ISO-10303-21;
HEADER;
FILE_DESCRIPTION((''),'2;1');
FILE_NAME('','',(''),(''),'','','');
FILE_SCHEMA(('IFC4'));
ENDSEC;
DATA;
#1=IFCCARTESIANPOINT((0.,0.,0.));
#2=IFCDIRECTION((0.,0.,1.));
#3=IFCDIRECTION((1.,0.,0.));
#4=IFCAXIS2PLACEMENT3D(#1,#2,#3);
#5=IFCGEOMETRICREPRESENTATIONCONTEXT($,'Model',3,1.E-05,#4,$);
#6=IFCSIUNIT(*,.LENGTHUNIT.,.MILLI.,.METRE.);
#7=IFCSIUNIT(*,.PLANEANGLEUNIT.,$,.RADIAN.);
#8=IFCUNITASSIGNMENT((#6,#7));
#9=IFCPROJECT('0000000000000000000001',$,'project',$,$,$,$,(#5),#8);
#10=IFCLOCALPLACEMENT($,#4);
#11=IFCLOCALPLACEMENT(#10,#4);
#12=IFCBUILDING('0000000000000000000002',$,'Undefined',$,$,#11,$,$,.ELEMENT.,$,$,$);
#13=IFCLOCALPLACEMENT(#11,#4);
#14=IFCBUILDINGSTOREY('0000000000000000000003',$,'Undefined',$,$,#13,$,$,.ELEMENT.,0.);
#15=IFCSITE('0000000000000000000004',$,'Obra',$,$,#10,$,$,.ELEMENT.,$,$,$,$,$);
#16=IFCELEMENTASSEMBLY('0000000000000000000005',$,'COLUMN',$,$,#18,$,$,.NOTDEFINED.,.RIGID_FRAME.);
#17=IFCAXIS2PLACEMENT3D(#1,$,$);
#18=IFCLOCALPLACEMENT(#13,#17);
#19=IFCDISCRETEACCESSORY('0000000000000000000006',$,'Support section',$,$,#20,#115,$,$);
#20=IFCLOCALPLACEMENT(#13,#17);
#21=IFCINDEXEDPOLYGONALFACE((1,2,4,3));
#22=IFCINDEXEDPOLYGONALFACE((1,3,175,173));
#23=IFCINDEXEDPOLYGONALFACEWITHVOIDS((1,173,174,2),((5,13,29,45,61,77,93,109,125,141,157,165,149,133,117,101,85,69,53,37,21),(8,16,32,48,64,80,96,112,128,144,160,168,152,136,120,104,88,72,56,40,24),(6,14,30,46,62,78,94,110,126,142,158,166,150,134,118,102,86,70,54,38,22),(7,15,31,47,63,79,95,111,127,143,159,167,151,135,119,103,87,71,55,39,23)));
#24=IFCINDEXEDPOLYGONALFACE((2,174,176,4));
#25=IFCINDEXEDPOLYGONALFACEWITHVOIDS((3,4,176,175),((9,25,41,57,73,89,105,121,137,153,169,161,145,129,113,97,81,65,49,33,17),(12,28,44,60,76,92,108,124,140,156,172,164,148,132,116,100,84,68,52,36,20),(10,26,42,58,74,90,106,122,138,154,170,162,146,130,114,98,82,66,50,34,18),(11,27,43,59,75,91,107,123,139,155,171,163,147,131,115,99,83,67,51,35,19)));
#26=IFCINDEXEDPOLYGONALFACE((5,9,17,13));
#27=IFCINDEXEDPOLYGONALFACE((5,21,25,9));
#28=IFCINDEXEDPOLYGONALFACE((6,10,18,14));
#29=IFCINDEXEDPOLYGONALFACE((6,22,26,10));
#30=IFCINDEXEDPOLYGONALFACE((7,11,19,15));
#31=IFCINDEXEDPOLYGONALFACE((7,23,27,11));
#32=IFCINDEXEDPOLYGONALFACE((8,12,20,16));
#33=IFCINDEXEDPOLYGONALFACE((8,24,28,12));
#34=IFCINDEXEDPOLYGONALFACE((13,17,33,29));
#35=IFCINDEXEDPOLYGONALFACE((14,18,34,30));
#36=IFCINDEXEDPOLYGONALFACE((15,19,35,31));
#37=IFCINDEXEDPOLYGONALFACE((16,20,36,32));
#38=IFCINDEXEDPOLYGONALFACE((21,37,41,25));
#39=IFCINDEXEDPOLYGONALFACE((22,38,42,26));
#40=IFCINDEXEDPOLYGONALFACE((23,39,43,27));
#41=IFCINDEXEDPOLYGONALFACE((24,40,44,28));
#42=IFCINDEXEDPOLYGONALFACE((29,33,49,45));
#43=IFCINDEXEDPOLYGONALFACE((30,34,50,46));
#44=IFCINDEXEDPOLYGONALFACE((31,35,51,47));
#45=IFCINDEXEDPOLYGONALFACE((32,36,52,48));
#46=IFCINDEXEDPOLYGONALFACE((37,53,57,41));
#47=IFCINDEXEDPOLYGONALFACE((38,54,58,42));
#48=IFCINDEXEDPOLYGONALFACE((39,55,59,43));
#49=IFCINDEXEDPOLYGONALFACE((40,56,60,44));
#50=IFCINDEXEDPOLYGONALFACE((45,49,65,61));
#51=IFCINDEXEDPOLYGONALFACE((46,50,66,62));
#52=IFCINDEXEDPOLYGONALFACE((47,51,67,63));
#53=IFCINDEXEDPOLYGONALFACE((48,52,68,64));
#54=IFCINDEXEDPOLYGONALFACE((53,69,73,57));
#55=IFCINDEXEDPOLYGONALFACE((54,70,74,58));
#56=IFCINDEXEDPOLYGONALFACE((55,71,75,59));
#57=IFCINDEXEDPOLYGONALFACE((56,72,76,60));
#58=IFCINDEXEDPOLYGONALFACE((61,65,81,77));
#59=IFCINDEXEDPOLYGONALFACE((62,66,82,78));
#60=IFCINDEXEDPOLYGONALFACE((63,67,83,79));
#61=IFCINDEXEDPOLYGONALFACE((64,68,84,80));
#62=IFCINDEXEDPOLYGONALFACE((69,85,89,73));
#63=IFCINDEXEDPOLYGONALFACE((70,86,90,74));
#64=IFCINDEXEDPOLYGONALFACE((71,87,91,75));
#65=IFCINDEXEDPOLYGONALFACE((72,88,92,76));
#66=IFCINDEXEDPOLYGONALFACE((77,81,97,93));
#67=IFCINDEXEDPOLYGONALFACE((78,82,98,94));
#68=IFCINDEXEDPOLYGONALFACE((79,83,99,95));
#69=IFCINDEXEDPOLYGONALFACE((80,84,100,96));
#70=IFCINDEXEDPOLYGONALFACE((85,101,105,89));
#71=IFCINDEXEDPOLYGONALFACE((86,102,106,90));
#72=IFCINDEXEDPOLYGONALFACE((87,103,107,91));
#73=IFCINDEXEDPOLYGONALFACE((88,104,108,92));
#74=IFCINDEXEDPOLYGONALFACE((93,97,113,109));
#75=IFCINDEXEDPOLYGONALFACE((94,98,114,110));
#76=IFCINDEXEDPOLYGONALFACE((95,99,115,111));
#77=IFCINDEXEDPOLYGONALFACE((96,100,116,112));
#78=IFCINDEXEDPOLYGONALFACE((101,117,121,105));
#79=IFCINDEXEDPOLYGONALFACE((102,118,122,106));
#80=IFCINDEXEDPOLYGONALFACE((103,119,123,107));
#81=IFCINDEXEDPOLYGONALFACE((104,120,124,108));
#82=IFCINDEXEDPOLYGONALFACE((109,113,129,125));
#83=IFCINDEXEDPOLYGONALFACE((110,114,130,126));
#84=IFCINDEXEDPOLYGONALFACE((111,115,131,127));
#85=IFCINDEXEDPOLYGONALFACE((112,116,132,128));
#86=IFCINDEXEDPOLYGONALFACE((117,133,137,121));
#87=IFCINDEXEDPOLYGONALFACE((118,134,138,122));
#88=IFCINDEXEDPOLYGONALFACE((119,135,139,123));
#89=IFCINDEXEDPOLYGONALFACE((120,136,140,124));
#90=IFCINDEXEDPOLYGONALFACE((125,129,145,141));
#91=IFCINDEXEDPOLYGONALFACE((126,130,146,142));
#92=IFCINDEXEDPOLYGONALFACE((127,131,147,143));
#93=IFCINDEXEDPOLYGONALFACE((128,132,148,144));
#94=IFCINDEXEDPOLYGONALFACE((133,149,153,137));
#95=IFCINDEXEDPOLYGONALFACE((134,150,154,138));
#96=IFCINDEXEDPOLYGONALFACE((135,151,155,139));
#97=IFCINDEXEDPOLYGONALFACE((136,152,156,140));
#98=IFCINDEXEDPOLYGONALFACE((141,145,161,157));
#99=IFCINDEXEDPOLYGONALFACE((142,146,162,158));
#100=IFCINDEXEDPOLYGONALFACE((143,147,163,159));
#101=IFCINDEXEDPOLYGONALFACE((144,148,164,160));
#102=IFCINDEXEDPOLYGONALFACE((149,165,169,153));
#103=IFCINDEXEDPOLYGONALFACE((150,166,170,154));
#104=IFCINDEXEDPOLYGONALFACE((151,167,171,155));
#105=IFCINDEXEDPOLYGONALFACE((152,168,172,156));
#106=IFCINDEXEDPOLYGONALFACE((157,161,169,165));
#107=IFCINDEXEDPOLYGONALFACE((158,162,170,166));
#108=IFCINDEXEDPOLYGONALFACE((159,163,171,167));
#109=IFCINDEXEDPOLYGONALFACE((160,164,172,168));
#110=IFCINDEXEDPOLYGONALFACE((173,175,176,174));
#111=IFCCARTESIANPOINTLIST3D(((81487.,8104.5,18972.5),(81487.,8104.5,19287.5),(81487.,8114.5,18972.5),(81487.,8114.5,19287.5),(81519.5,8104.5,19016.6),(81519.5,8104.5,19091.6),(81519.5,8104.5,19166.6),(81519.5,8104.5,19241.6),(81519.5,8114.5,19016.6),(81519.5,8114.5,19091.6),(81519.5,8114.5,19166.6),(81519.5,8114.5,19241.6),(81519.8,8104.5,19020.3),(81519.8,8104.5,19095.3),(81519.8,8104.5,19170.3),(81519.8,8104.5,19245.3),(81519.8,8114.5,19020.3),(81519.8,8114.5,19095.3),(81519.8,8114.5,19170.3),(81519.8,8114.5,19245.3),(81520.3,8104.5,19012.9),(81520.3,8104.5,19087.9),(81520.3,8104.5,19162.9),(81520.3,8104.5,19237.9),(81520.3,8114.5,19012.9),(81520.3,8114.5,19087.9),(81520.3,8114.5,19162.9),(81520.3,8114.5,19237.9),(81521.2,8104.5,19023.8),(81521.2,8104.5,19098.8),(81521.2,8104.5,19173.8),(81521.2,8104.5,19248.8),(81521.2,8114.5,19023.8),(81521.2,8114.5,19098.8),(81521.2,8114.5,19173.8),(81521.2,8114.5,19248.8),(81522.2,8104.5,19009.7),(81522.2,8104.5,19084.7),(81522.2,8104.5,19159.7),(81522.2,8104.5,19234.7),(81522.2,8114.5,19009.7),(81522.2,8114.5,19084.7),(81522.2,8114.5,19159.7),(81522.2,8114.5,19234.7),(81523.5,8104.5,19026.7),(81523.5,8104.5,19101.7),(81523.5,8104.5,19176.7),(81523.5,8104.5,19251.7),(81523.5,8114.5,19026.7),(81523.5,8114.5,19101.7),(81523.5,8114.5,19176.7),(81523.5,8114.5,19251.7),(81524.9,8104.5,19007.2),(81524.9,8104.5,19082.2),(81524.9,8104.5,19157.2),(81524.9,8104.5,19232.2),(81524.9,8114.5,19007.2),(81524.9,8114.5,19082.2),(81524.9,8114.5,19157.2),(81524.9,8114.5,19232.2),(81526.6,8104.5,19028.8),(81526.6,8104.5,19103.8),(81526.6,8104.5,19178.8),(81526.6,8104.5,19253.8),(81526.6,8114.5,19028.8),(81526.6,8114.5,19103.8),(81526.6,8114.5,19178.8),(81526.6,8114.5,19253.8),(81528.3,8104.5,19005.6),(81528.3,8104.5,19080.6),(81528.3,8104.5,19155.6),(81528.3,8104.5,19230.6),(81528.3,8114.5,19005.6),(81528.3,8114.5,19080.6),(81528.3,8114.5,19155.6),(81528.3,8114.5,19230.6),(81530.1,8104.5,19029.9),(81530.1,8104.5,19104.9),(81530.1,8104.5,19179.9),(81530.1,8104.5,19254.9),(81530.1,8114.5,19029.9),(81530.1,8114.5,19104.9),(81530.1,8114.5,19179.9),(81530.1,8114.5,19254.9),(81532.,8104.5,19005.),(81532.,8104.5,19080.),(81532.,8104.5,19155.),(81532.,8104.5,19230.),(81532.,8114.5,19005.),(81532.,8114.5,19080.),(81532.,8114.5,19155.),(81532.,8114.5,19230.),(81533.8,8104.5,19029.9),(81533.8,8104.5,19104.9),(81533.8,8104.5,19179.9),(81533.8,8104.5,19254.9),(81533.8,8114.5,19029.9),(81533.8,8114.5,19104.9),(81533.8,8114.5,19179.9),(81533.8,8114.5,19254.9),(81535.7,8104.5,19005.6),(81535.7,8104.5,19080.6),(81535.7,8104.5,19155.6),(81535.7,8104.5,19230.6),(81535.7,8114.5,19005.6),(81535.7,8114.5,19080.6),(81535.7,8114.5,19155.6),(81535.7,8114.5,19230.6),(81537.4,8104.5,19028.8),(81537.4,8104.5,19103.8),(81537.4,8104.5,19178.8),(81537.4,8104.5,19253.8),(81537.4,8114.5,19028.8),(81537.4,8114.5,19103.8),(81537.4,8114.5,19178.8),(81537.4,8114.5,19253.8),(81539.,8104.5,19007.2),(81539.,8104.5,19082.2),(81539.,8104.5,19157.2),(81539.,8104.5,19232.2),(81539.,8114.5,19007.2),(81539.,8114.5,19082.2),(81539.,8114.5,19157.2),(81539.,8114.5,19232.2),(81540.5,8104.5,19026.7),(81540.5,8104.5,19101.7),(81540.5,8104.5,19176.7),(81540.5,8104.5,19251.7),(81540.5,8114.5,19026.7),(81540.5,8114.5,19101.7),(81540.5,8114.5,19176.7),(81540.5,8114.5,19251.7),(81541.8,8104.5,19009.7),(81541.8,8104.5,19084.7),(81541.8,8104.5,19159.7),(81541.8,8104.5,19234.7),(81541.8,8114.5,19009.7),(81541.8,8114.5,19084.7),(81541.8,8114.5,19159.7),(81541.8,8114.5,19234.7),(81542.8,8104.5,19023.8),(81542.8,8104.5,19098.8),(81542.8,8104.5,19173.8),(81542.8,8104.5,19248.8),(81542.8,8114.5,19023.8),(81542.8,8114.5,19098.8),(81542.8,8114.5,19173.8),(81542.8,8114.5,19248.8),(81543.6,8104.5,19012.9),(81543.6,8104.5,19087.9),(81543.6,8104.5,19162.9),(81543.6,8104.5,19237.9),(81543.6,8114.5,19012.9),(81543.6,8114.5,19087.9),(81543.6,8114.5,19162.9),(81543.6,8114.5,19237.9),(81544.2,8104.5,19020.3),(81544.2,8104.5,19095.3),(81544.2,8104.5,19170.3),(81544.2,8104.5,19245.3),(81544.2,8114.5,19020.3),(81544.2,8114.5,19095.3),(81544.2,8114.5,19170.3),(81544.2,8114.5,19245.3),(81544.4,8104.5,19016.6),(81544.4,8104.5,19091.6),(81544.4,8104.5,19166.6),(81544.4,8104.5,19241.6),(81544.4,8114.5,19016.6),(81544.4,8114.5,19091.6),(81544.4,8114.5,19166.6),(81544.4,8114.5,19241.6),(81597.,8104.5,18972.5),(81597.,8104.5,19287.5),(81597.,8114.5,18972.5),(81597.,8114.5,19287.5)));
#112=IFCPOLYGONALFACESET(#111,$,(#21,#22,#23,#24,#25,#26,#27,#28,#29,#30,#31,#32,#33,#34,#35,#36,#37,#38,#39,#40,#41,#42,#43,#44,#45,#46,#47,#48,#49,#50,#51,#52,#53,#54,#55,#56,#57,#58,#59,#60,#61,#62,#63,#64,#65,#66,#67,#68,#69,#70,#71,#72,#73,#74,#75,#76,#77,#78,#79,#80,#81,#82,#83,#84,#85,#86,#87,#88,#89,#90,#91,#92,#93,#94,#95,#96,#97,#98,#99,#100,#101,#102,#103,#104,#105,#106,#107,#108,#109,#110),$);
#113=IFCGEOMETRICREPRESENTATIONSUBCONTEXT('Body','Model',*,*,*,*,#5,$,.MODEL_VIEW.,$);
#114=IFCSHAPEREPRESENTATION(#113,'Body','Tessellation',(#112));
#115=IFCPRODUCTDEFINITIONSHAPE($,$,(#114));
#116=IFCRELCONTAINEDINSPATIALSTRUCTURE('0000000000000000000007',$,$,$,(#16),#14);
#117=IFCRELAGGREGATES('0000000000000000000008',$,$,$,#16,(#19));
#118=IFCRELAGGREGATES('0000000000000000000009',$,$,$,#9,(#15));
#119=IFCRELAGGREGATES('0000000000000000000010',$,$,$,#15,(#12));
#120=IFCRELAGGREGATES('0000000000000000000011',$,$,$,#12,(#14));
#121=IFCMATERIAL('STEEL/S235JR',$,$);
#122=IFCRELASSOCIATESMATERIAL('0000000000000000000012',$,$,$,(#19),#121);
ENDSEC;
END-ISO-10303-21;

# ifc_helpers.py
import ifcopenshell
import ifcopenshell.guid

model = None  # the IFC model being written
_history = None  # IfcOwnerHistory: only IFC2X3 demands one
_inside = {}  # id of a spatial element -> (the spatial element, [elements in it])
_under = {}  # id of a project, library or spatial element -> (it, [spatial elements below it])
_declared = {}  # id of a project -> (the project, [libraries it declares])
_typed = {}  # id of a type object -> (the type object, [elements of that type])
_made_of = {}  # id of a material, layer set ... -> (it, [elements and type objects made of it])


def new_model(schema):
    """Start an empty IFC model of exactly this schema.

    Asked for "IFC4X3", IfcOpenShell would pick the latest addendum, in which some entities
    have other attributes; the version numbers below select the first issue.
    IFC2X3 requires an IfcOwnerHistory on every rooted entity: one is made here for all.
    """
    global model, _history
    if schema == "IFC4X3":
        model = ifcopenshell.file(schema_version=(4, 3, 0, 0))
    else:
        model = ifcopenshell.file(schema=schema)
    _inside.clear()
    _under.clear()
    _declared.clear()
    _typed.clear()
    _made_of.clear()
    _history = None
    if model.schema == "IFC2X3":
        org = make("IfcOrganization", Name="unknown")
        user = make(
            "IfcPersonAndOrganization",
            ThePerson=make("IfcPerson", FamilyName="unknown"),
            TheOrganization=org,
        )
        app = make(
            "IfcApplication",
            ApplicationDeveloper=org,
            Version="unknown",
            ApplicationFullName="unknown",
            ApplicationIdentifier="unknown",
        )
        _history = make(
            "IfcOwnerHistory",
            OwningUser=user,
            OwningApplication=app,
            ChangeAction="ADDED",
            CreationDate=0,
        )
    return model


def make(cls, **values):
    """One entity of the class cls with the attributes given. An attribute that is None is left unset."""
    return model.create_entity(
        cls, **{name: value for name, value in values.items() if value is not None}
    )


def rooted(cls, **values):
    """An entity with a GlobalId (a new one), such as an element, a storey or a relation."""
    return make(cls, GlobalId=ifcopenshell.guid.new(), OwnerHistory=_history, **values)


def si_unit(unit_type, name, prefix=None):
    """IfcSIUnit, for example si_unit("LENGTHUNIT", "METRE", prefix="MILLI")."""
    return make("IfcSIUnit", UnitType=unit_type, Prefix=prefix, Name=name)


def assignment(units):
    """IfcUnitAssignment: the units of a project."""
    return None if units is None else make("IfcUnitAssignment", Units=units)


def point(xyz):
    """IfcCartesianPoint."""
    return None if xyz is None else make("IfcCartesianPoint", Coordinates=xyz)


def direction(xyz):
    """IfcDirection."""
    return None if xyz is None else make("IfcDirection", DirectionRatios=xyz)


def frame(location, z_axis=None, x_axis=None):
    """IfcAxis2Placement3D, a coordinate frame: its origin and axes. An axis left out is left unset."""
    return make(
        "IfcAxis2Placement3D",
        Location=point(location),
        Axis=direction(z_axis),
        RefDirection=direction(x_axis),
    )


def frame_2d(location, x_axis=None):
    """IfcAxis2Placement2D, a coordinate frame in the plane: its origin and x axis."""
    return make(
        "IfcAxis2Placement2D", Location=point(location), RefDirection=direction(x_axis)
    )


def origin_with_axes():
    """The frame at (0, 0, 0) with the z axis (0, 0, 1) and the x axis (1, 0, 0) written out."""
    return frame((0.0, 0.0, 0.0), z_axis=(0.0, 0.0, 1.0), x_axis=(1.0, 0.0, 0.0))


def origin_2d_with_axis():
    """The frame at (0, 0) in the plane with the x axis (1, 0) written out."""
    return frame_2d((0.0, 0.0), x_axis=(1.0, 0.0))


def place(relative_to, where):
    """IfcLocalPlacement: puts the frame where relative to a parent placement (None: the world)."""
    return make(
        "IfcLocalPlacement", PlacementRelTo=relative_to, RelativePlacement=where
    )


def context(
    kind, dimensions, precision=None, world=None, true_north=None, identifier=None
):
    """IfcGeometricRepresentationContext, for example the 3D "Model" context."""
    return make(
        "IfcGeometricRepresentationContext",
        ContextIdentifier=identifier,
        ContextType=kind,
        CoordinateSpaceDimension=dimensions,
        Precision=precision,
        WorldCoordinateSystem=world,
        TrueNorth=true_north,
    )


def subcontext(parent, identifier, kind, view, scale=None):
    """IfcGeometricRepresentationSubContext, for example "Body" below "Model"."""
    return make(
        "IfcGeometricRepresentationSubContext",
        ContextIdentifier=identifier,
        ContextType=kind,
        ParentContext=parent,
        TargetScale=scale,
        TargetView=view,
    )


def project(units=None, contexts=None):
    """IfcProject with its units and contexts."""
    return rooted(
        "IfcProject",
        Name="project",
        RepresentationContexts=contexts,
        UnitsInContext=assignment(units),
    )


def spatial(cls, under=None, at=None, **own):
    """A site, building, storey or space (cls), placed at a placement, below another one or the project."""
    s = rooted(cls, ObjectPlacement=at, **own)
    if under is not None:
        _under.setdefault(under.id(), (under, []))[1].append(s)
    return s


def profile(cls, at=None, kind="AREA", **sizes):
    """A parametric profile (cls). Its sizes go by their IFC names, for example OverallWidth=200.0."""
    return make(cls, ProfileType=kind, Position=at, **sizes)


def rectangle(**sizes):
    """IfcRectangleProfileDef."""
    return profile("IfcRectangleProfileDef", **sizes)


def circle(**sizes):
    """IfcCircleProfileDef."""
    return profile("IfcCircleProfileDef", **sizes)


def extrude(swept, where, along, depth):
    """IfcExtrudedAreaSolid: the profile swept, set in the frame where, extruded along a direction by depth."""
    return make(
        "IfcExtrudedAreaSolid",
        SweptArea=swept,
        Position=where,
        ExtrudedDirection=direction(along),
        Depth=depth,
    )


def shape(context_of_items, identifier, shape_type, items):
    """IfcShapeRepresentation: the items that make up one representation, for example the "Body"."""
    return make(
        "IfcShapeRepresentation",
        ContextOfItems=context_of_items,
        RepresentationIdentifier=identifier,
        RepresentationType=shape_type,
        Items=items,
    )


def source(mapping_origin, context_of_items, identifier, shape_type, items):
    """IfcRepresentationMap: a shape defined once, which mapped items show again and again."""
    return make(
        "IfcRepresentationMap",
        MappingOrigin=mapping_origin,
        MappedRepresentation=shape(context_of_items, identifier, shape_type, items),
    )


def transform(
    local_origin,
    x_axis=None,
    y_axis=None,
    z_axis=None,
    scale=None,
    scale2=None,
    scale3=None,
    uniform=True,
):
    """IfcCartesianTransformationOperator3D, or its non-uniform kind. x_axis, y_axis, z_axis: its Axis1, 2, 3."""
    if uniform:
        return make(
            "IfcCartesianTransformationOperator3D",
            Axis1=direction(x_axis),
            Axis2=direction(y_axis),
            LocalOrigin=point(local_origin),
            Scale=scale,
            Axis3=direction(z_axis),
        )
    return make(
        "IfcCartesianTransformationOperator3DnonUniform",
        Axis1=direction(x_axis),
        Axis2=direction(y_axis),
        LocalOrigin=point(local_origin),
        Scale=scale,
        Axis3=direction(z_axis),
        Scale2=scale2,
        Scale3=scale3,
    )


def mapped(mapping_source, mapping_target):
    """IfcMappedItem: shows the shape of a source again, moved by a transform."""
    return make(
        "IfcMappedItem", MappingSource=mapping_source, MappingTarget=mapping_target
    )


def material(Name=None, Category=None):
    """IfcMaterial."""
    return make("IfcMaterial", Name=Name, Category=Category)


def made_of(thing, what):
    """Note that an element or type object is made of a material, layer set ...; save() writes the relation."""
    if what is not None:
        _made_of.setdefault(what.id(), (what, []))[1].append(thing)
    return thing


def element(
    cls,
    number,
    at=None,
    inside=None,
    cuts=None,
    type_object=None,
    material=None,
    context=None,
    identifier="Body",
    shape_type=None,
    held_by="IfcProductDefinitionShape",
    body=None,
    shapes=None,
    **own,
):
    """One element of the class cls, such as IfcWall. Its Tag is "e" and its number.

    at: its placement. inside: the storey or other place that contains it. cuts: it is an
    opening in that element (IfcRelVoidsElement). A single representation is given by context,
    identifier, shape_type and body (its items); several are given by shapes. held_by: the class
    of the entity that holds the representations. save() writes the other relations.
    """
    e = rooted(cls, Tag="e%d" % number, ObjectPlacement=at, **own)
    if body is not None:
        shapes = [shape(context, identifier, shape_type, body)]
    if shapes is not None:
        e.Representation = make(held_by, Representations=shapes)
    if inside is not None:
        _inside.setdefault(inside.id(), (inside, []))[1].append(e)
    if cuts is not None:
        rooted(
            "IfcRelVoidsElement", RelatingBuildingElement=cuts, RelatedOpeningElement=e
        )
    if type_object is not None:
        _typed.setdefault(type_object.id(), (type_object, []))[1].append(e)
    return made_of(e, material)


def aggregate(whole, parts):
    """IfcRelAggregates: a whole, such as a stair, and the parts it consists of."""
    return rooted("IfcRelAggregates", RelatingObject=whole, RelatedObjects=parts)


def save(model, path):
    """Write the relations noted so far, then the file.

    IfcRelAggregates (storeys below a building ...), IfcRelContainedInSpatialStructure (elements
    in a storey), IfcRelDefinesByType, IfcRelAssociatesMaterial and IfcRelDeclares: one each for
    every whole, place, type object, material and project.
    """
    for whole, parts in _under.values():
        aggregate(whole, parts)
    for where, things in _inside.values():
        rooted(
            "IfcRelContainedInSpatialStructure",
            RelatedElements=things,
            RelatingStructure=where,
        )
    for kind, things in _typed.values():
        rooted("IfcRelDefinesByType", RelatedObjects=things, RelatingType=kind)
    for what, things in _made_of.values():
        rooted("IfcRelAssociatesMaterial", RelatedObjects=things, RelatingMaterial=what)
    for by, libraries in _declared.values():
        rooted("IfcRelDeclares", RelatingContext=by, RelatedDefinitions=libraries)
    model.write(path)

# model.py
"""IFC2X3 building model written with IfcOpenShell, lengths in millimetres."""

from ifc_helpers import new_model, si_unit, frame, origin_with_axes, origin_2d_with_axis, place, context, subcontext, project, spatial, rectangle, circle, extrude, source, transform, mapped, material, element, aggregate, save


model = new_model("IFC2X3")

# Units and contexts
model_context = context("Model", 3, precision=1e-05, world=origin_with_axes())
body_context = subcontext(model_context, "Body", "Model", "MODEL_VIEW")
ifc_project = project(units=[si_unit("LENGTHUNIT", "METRE", prefix="MILLI"), si_unit("PLANEANGLEUNIT", "RADIAN")], contexts=[model_context])

# Site, building, storey
site_placement = place(None, origin_with_axes())
site = spatial("IfcSite", under=ifc_project, at=site_placement, Name="Obra", CompositionType="ELEMENT")
building_placement = place(site_placement, origin_with_axes())
building = spatial("IfcBuilding", under=site, at=building_placement, Name="Undefined", CompositionType="ELEMENT")
storey_placement = place(building_placement, origin_with_axes())
storey = spatial("IfcBuildingStorey", under=building, at=storey_placement, Name="Undefined", CompositionType="ELEMENT", Elevation=0.0)

# Shared definitions
ifc_material_1 = material(Name="STEEL/S235JR")

# Element assembly, discrete accessory, opening
assembly_1_placement = place(storey_placement, origin_with_axes())
assembly_1 = element("IfcElementAssembly", 1, at=assembly_1_placement, inside=storey, Name="COLUMN", AssemblyPlace="NOTDEFINED", PredefinedType="RIGID_FRAME")
discrete_accessory_1_placement = place(assembly_1_placement, frame((81542.0, 8109.5, 18972.5), z_axis=(0.0, 0.0, 1.0), x_axis=(1.0, 0.0, 0.0)))
discrete_accessory_1 = element("IfcDiscreteAccessory", 2, at=discrete_accessory_1_placement, material=ifc_material_1, Name="Support section", context=body_context, shape_type="SweptSolid", body=[
    extrude(rectangle(XDim=10.0, YDim=110.0, at=origin_2d_with_axis()), frame((0.0, 0.0, 315.0), z_axis=(0.0, 0.0, -1.0), x_axis=(0.0, 1.0, 0.0)), (0.0, 0.0, 1.0), 315.0),
])
shared_shape_1 = source(origin_with_axes(), body_context, "Body", "SweptSolid", [
    extrude(circle(Radius=12.5, at=origin_2d_with_axis()), frame((0.0, 5.7, 0.0), z_axis=(0.0, 1.0, 0.0), x_axis=(1.0, 0.0, 0.0)), (0.0, 0.0, 1.0), 10.2),
])
opening_1_placement = place(assembly_1_placement, frame((81577.0, 8120.2, 19350.0), z_axis=(-1.0, 0.0, 0.0), x_axis=(0.0, 0.0, -1.0)))
element("IfcOpeningElement", 3, at=opening_1_placement, cuts=discrete_accessory_1, ObjectType="Opening", context=body_context, shape_type="MappedRepresentation", body=[
    mapped(shared_shape_1, transform((107.5, 0.0, 45.0))),
    mapped(shared_shape_1, transform((182.5, 0.0, 45.0))),
    mapped(shared_shape_1, transform((257.5, 0.0, 45.0))),
    mapped(shared_shape_1, transform((332.5, 0.0, 45.0))),
])
aggregate(assembly_1, [discrete_accessory_1])

save(model, "model.ifc")
